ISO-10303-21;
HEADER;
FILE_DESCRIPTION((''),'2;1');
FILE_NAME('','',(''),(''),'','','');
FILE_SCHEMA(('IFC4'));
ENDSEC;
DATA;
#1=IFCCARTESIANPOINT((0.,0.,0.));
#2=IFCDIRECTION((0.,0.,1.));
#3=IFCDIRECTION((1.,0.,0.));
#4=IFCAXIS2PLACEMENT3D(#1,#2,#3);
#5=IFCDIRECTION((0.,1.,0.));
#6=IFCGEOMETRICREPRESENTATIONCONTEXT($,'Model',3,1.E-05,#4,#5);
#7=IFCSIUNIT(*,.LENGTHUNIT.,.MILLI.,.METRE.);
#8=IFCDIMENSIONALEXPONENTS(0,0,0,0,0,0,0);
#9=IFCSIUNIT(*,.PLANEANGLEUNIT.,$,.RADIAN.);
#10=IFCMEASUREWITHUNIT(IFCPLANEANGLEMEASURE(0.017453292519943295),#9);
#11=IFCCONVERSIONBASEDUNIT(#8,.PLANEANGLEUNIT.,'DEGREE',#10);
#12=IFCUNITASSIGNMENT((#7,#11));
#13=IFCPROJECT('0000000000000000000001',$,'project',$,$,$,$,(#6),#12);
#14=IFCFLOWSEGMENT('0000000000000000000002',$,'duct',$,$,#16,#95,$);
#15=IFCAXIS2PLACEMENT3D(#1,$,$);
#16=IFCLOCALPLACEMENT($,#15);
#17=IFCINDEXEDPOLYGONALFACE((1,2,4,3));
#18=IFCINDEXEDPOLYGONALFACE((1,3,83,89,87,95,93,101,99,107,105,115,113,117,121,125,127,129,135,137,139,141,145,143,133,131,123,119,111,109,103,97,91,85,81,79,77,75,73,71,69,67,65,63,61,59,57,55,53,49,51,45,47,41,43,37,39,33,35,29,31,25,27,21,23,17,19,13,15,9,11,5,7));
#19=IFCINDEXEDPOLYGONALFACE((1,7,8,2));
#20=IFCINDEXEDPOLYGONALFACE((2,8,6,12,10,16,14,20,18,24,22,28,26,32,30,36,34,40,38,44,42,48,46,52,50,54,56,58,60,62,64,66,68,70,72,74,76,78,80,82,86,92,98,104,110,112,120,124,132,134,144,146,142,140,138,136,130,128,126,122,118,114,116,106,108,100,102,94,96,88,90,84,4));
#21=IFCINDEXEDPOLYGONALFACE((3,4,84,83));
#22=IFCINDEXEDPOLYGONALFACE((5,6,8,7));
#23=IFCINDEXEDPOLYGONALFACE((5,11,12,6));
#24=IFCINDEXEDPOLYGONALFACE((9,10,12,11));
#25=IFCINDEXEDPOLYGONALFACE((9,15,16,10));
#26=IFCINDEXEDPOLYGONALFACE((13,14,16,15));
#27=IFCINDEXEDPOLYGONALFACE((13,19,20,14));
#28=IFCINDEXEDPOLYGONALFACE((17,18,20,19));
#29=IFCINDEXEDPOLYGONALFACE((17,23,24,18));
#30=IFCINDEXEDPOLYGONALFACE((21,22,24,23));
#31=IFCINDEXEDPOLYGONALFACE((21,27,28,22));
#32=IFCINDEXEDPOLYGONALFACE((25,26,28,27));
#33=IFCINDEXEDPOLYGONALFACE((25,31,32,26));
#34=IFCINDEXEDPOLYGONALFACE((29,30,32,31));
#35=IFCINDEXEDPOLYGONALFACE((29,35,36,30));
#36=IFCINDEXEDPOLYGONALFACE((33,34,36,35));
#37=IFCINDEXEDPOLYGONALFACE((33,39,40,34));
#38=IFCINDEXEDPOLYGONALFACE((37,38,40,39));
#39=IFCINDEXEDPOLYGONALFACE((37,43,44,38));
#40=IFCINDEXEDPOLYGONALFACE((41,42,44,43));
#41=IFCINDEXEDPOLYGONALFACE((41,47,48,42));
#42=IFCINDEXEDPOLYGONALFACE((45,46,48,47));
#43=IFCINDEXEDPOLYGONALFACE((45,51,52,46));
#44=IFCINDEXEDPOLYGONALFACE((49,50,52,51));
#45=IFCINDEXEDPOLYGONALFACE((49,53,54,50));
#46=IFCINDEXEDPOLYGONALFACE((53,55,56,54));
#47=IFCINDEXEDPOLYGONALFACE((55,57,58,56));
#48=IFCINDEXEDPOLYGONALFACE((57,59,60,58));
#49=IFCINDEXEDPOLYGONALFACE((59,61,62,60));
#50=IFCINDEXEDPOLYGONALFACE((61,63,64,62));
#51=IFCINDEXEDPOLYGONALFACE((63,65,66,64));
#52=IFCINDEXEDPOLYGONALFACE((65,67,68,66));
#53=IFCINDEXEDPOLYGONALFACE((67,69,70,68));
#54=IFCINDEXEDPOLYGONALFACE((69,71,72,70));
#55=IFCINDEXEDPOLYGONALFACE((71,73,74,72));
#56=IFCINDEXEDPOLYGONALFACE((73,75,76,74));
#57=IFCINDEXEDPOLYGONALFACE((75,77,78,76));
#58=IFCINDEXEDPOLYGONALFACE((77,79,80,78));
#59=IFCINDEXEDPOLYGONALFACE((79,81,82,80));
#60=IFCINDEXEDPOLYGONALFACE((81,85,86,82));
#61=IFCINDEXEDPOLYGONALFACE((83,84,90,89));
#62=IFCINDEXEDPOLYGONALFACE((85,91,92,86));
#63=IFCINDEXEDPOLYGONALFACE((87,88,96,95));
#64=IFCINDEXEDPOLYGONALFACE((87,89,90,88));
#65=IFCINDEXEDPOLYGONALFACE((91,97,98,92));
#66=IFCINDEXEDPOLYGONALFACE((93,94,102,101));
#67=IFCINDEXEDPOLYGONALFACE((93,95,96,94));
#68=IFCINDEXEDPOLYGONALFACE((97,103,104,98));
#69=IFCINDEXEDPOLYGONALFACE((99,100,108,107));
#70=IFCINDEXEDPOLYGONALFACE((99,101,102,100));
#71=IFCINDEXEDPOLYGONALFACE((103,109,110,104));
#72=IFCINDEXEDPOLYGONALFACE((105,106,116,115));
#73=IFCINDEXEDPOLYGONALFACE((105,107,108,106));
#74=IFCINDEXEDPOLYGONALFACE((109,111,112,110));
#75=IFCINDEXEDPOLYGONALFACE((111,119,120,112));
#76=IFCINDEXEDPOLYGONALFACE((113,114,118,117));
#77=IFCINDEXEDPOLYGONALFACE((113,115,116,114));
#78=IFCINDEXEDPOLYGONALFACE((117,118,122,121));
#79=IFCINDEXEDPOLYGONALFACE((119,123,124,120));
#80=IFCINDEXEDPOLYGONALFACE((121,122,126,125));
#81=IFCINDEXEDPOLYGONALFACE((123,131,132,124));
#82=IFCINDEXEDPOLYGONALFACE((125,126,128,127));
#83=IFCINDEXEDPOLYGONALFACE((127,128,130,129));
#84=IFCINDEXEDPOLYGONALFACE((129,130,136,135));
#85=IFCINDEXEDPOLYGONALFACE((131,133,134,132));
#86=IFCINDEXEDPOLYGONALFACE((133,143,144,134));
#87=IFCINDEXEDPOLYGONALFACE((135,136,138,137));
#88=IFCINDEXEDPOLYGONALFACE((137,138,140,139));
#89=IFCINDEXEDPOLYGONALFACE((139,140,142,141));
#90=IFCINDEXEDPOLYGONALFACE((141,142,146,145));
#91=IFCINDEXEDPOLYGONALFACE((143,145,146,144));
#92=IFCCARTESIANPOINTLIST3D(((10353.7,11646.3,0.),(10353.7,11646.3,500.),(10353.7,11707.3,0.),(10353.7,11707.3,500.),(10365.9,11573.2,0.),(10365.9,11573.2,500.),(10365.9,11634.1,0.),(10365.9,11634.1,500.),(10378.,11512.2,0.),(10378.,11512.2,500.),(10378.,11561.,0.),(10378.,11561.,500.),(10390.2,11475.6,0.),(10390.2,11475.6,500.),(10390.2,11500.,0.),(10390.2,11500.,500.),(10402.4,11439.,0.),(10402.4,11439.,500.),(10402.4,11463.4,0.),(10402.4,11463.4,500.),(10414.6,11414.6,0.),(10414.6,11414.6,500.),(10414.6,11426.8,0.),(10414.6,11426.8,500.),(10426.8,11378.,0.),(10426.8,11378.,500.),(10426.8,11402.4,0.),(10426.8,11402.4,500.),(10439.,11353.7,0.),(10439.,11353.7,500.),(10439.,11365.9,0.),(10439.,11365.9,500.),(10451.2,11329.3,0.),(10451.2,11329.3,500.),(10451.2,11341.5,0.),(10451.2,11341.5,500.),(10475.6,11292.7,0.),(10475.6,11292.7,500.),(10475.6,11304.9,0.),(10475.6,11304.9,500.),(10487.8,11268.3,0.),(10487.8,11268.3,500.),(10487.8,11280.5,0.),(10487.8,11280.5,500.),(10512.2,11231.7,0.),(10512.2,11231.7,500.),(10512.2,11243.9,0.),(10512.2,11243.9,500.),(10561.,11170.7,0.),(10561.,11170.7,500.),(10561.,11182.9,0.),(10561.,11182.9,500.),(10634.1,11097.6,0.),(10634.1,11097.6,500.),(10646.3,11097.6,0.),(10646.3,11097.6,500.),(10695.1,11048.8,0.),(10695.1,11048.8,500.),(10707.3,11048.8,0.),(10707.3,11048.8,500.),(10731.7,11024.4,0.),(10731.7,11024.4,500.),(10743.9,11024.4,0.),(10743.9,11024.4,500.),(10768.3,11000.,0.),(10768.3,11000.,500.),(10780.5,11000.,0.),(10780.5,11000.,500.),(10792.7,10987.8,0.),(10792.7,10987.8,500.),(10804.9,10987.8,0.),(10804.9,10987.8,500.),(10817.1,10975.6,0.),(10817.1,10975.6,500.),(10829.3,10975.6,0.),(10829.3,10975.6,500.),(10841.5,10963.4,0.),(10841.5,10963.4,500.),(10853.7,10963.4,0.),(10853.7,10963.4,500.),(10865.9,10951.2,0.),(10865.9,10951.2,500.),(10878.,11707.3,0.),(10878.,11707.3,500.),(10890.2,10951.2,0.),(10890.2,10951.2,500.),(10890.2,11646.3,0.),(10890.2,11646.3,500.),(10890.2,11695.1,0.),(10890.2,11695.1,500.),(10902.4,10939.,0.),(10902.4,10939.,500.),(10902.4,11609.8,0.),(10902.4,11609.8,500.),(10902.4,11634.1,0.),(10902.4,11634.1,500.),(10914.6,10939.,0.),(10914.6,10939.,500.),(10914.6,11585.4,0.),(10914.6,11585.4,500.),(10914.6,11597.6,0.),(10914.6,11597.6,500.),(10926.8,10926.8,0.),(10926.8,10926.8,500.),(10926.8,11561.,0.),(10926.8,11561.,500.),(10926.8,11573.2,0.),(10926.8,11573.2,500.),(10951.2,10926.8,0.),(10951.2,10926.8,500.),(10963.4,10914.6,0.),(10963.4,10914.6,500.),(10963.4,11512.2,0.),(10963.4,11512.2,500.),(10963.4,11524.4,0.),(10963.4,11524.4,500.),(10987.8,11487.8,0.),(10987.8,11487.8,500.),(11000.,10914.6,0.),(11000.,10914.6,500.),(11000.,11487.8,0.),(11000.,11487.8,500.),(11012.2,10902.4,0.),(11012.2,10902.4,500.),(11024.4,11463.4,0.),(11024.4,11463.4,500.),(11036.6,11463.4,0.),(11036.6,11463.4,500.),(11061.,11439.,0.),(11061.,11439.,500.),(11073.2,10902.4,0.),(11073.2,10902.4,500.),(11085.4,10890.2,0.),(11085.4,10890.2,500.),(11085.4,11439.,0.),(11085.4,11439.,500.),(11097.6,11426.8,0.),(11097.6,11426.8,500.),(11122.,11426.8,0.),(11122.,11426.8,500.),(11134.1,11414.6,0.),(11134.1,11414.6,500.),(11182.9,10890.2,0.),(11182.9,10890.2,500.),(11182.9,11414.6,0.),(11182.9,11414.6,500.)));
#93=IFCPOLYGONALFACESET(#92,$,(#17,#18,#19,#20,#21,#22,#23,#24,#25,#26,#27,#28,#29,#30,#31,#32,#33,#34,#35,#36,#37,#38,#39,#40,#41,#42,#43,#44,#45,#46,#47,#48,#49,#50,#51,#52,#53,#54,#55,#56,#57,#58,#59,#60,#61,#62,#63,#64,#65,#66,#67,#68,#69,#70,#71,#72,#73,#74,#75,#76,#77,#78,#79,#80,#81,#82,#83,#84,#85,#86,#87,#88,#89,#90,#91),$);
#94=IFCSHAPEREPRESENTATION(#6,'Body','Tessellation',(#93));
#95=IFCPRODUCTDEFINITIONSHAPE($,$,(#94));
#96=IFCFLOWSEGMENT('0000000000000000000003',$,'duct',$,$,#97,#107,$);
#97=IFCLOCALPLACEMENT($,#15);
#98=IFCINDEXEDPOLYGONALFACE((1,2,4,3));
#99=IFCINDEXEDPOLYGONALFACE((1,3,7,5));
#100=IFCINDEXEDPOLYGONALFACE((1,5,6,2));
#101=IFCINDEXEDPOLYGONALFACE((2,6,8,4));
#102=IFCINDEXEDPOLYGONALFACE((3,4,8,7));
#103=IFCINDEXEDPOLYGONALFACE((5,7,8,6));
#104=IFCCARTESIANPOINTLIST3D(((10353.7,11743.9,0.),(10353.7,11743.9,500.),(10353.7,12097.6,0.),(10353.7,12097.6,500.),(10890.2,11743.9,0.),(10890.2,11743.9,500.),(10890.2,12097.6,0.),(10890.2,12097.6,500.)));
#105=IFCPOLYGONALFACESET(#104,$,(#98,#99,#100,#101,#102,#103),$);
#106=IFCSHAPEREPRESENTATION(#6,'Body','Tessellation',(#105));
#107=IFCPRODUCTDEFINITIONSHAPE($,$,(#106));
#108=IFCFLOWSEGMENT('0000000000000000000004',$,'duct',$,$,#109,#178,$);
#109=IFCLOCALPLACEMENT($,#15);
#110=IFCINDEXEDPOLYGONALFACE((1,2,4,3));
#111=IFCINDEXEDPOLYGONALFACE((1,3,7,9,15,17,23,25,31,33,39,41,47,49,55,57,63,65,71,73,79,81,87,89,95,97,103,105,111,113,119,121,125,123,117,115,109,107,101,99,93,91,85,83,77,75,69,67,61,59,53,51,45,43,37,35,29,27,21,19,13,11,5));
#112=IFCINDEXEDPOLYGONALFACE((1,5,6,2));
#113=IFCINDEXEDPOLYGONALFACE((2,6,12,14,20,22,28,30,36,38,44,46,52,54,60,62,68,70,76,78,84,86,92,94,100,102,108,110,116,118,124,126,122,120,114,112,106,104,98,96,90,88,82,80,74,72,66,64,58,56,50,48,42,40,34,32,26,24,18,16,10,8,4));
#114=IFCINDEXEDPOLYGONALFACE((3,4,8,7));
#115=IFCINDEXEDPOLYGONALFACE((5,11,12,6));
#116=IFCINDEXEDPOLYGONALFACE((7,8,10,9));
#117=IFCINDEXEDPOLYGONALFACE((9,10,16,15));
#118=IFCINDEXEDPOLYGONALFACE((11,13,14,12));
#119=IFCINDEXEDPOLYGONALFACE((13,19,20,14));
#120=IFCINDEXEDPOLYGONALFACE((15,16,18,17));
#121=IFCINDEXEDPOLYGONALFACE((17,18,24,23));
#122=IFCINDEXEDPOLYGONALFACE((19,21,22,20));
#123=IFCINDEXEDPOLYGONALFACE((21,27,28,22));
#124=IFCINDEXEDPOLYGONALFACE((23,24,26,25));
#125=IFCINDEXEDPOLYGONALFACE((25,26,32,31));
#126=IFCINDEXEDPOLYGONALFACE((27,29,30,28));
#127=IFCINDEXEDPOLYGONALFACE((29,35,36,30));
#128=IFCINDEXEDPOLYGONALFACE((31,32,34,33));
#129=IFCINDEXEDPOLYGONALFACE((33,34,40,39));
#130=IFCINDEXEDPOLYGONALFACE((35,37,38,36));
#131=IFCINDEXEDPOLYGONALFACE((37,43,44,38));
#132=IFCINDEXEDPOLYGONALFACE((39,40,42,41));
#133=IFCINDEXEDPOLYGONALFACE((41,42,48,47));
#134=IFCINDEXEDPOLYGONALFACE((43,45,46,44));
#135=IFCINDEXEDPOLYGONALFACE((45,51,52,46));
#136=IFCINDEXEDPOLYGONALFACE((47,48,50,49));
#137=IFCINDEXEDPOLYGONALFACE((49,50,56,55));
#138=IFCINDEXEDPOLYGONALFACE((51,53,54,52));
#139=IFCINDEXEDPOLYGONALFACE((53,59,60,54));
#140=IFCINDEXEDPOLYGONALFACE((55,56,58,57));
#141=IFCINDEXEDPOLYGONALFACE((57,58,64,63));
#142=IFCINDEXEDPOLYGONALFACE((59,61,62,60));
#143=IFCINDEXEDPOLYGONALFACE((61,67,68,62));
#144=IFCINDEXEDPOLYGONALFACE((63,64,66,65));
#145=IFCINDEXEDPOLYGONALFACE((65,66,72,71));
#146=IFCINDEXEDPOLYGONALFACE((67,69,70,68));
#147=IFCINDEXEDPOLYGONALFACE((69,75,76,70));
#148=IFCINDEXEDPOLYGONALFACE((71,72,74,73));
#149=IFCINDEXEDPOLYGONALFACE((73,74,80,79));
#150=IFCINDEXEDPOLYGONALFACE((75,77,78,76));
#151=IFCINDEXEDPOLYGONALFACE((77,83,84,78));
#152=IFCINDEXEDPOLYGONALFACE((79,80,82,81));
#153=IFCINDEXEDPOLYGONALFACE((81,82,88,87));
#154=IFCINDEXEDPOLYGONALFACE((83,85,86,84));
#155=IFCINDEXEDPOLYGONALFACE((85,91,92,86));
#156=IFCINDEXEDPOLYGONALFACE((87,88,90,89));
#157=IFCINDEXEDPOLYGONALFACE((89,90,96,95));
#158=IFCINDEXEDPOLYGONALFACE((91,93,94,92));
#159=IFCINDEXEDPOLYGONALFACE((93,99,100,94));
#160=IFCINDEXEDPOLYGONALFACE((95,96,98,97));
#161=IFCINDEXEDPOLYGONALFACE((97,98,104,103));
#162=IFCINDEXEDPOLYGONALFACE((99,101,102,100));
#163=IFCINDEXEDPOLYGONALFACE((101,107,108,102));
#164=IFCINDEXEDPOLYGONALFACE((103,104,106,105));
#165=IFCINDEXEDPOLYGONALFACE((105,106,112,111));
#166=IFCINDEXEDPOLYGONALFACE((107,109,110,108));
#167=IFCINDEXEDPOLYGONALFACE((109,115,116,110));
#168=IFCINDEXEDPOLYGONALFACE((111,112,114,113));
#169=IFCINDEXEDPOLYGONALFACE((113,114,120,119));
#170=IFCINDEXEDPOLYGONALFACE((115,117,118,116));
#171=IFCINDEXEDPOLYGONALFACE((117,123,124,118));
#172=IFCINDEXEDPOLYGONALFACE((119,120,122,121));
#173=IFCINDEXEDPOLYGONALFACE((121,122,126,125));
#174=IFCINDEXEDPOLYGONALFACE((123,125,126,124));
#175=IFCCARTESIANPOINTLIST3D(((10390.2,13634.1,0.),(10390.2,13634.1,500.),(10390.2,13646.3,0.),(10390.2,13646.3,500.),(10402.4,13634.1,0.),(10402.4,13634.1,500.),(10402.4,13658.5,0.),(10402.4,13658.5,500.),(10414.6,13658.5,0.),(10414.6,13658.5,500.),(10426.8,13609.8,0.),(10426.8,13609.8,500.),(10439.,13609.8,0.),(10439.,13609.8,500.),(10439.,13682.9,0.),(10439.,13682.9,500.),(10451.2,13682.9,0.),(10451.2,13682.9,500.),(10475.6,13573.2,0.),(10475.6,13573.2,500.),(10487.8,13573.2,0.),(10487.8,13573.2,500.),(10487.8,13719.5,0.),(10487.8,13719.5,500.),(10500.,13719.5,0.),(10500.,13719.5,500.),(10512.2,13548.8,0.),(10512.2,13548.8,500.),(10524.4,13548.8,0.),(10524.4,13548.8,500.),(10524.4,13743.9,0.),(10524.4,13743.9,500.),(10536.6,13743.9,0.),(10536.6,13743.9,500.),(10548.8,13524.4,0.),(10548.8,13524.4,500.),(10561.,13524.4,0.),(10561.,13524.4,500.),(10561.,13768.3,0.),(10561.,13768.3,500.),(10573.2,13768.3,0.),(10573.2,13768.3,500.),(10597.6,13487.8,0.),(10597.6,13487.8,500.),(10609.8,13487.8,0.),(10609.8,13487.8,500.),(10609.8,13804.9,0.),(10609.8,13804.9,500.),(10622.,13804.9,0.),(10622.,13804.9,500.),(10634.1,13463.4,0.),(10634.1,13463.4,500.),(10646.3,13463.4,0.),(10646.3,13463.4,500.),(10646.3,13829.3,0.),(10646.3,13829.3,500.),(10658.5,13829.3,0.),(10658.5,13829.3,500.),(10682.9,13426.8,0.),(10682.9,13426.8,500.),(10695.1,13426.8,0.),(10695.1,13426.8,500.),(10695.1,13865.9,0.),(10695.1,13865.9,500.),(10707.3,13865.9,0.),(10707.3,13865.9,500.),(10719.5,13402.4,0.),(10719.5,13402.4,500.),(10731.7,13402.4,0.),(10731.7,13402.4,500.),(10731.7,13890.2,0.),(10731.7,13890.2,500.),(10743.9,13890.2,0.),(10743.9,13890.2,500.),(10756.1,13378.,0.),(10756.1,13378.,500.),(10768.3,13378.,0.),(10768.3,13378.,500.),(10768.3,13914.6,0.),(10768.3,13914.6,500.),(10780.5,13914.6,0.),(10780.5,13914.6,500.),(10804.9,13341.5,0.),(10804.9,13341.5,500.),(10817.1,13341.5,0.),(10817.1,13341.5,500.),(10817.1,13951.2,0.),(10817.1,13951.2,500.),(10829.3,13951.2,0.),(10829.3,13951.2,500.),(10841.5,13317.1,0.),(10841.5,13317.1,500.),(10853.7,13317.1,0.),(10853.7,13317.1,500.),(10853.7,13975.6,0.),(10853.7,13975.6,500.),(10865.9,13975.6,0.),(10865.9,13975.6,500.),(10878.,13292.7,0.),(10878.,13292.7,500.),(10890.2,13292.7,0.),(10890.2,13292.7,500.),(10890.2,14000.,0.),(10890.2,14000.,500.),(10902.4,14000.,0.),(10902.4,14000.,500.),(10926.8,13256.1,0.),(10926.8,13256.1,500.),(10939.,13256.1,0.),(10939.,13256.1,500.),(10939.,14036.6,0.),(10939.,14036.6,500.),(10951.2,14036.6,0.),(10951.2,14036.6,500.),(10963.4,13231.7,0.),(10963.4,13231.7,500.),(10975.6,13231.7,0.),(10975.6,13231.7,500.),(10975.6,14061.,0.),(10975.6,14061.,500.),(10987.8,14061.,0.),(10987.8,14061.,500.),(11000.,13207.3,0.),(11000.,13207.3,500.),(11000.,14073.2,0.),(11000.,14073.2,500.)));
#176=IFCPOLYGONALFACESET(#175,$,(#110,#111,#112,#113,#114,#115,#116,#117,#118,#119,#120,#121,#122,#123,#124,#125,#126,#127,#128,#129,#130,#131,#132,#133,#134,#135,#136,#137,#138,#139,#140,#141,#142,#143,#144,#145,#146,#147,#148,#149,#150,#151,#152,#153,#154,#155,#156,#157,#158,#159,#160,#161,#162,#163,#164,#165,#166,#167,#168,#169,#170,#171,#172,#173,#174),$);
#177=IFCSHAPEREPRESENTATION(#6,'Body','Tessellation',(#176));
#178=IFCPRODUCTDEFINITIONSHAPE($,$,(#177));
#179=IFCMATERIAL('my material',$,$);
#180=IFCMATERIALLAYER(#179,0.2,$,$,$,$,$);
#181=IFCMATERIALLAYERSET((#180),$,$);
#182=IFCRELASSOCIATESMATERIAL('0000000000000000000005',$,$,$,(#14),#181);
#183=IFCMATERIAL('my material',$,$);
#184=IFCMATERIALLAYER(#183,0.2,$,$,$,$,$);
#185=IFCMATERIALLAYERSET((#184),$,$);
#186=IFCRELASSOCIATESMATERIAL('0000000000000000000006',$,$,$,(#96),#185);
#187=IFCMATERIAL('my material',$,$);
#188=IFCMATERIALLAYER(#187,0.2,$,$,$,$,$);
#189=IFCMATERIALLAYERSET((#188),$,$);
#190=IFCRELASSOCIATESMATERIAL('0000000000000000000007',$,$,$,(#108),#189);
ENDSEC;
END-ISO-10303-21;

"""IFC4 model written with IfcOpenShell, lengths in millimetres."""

from ifc_helpers import new_model, entity, si_unit, converted_unit, direction, origin_with_axes, place, context, project, polyline, outline, extrude, material, layer, layer_set, layer_usage, element, save


model = new_model("IFC4")

# Units and contexts
model_context = context("Model", 3, precision=1e-05, world=origin_with_axes(), true_north=direction((0.0, 1.0, 0.0)))
ifc_project = project(units=[si_unit("LENGTHUNIT", "METRE", prefix="MILLI"), converted_unit("PLANEANGLEUNIT", "DEGREE", entity("IfcPlaneAngleMeasure", 0.017453292519943295), si_unit("PLANEANGLEUNIT", "RADIAN"), dimensions=[0, 0, 0, 0, 0, 0, 0])], contexts=[model_context])

# Flow segments
ifc_material_1 = material(Name="my material")
ifc_layer_1 = layer(ifc_material_1, 0.2)
ifc_layer_set_1 = layer_set([ifc_layer_1])
ifc_layer_usage_1 = layer_usage(ifc_layer_set_1, "AXIS2", "POSITIVE", -0.1)
flow_segment_1_placement = place(None, origin_with_axes())
element("IfcFlowSegment", 1, at=flow_segment_1_placement, material=ifc_layer_usage_1, Name="duct", context=model_context, shape_type="SweptSolid", body=[
    extrude(outline(polyline([(10353.7, 11646.3), (10365.9, 11634.1), (10365.9, 11573.2), (10378.0, 11561.0), (10378.0, 11512.2), (10390.2, 11500.0), (10390.2, 11475.6), (10402.4, 11463.4), (10402.4, 11439.0), (10414.6, 11426.8), (10414.6, 11414.6), (10426.8, 11402.4), (10426.8, 11378.0), (10439.0, 11365.9), (10439.0, 11353.7), (10451.2, 11341.5), (10451.2, 11329.3), (10475.6, 11304.9), (10475.6, 11292.7), (10487.8, 11280.5), (10487.8, 11268.3), (10512.2, 11243.9), (10512.2, 11231.7), (10561.0, 11182.9), (10561.0, 11170.7), (10634.1, 11097.6), (10646.3, 11097.6), (10695.1, 11048.8), (10707.3, 11048.8), (10731.7, 11024.4), (10743.9, 11024.4), (10768.3, 11000.0), (10780.5, 11000.0), (10792.7, 10987.8), (10804.9, 10987.8), (10817.1, 10975.6), (10829.3, 10975.6), (10841.5, 10963.4), (10853.7, 10963.4), (10865.9, 10951.2), (10890.2, 10951.2), (10902.4, 10939.0), (10914.6, 10939.0), (10926.8, 10926.8), (10951.2, 10926.8), (10963.4, 10914.6), (11000.0, 10914.6), (11012.2, 10902.4), (11073.2, 10902.4), (11085.4, 10890.2), (11182.9, 10890.2), (11182.9, 11414.6), (11134.1, 11414.6), (11122.0, 11426.8), (11097.6, 11426.8), (11085.4, 11439.0), (11061.0, 11439.0), (11036.6, 11463.4), (11024.4, 11463.4), (11000.0, 11487.8), (10987.8, 11487.8), (10963.4, 11512.2), (10963.4, 11524.4), (10926.8, 11561.0), (10926.8, 11573.2), (10914.6, 11585.4), (10914.6, 11597.6), (10902.4, 11609.8), (10902.4, 11634.1), (10890.2, 11646.3), (10890.2, 11695.1), (10878.0, 11707.3), (10353.7, 11707.3), (10353.7, 11646.3)])), origin_with_axes(), (0.0, 0.0, 1.0), 500.0),
])
ifc_material_2 = material(Name="my material")
ifc_layer_2 = layer(ifc_material_2, 0.2)
ifc_layer_set_2 = layer_set([ifc_layer_2])
ifc_layer_usage_2 = layer_usage(ifc_layer_set_2, "AXIS2", "POSITIVE", -0.1)
flow_segment_2_placement = place(None, origin_with_axes())
element("IfcFlowSegment", 2, at=flow_segment_2_placement, material=ifc_layer_usage_2, Name="duct", context=model_context, shape_type="SweptSolid", body=[
    extrude(outline(polyline([(10353.7, 11743.9), (10890.2, 11743.9), (10890.2, 12097.6), (10353.7, 12097.6), (10353.7, 11743.9)])), origin_with_axes(), (0.0, 0.0, 1.0), 500.0),
])
ifc_material_3 = material(Name="my material")
ifc_layer_3 = layer(ifc_material_3, 0.2)
ifc_layer_set_3 = layer_set([ifc_layer_3])
ifc_layer_usage_3 = layer_usage(ifc_layer_set_3, "AXIS2", "POSITIVE", -0.1)
flow_segment_3_placement = place(None, origin_with_axes())
element("IfcFlowSegment", 3, at=flow_segment_3_placement, material=ifc_layer_usage_3, Name="duct", context=model_context, shape_type="SweptSolid", body=[
    extrude(outline(polyline([(10390.2, 13634.1), (10402.4, 13634.1), (10426.8, 13609.8), (10439.0, 13609.8), (10475.6, 13573.2), (10487.8, 13573.2), (10512.2, 13548.8), (10524.4, 13548.8), (10548.8, 13524.4), (10561.0, 13524.4), (10597.6, 13487.8), (10609.8, 13487.8), (10634.1, 13463.4), (10646.3, 13463.4), (10682.9, 13426.8), (10695.1, 13426.8), (10719.5, 13402.4), (10731.7, 13402.4), (10756.1, 13378.0), (10768.3, 13378.0), (10804.9, 13341.5), (10817.1, 13341.5), (10841.5, 13317.1), (10853.7, 13317.1), (10878.0, 13292.7), (10890.2, 13292.7), (10926.8, 13256.1), (10939.0, 13256.1), (10963.4, 13231.7), (10975.6, 13231.7), (11000.0, 13207.3), (11000.0, 14073.2), (10987.8, 14061.0), (10975.6, 14061.0), (10951.2, 14036.6), (10939.0, 14036.6), (10902.4, 14000.0), (10890.2, 14000.0), (10865.9, 13975.6), (10853.7, 13975.6), (10829.3, 13951.2), (10817.1, 13951.2), (10780.5, 13914.6), (10768.3, 13914.6), (10743.9, 13890.2), (10731.7, 13890.2), (10707.3, 13865.9), (10695.1, 13865.9), (10658.5, 13829.3), (10646.3, 13829.3), (10622.0, 13804.9), (10609.8, 13804.9), (10573.2, 13768.3), (10561.0, 13768.3), (10536.6, 13743.9), (10524.4, 13743.9), (10500.0, 13719.5), (10487.8, 13719.5), (10451.2, 13682.9), (10439.0, 13682.9), (10414.6, 13658.5), (10402.4, 13658.5), (10390.2, 13646.3), (10390.2, 13634.1)])), origin_with_axes(), (0.0, 0.0, 1.0), 500.0),
])

save(model, "model.ifc")
